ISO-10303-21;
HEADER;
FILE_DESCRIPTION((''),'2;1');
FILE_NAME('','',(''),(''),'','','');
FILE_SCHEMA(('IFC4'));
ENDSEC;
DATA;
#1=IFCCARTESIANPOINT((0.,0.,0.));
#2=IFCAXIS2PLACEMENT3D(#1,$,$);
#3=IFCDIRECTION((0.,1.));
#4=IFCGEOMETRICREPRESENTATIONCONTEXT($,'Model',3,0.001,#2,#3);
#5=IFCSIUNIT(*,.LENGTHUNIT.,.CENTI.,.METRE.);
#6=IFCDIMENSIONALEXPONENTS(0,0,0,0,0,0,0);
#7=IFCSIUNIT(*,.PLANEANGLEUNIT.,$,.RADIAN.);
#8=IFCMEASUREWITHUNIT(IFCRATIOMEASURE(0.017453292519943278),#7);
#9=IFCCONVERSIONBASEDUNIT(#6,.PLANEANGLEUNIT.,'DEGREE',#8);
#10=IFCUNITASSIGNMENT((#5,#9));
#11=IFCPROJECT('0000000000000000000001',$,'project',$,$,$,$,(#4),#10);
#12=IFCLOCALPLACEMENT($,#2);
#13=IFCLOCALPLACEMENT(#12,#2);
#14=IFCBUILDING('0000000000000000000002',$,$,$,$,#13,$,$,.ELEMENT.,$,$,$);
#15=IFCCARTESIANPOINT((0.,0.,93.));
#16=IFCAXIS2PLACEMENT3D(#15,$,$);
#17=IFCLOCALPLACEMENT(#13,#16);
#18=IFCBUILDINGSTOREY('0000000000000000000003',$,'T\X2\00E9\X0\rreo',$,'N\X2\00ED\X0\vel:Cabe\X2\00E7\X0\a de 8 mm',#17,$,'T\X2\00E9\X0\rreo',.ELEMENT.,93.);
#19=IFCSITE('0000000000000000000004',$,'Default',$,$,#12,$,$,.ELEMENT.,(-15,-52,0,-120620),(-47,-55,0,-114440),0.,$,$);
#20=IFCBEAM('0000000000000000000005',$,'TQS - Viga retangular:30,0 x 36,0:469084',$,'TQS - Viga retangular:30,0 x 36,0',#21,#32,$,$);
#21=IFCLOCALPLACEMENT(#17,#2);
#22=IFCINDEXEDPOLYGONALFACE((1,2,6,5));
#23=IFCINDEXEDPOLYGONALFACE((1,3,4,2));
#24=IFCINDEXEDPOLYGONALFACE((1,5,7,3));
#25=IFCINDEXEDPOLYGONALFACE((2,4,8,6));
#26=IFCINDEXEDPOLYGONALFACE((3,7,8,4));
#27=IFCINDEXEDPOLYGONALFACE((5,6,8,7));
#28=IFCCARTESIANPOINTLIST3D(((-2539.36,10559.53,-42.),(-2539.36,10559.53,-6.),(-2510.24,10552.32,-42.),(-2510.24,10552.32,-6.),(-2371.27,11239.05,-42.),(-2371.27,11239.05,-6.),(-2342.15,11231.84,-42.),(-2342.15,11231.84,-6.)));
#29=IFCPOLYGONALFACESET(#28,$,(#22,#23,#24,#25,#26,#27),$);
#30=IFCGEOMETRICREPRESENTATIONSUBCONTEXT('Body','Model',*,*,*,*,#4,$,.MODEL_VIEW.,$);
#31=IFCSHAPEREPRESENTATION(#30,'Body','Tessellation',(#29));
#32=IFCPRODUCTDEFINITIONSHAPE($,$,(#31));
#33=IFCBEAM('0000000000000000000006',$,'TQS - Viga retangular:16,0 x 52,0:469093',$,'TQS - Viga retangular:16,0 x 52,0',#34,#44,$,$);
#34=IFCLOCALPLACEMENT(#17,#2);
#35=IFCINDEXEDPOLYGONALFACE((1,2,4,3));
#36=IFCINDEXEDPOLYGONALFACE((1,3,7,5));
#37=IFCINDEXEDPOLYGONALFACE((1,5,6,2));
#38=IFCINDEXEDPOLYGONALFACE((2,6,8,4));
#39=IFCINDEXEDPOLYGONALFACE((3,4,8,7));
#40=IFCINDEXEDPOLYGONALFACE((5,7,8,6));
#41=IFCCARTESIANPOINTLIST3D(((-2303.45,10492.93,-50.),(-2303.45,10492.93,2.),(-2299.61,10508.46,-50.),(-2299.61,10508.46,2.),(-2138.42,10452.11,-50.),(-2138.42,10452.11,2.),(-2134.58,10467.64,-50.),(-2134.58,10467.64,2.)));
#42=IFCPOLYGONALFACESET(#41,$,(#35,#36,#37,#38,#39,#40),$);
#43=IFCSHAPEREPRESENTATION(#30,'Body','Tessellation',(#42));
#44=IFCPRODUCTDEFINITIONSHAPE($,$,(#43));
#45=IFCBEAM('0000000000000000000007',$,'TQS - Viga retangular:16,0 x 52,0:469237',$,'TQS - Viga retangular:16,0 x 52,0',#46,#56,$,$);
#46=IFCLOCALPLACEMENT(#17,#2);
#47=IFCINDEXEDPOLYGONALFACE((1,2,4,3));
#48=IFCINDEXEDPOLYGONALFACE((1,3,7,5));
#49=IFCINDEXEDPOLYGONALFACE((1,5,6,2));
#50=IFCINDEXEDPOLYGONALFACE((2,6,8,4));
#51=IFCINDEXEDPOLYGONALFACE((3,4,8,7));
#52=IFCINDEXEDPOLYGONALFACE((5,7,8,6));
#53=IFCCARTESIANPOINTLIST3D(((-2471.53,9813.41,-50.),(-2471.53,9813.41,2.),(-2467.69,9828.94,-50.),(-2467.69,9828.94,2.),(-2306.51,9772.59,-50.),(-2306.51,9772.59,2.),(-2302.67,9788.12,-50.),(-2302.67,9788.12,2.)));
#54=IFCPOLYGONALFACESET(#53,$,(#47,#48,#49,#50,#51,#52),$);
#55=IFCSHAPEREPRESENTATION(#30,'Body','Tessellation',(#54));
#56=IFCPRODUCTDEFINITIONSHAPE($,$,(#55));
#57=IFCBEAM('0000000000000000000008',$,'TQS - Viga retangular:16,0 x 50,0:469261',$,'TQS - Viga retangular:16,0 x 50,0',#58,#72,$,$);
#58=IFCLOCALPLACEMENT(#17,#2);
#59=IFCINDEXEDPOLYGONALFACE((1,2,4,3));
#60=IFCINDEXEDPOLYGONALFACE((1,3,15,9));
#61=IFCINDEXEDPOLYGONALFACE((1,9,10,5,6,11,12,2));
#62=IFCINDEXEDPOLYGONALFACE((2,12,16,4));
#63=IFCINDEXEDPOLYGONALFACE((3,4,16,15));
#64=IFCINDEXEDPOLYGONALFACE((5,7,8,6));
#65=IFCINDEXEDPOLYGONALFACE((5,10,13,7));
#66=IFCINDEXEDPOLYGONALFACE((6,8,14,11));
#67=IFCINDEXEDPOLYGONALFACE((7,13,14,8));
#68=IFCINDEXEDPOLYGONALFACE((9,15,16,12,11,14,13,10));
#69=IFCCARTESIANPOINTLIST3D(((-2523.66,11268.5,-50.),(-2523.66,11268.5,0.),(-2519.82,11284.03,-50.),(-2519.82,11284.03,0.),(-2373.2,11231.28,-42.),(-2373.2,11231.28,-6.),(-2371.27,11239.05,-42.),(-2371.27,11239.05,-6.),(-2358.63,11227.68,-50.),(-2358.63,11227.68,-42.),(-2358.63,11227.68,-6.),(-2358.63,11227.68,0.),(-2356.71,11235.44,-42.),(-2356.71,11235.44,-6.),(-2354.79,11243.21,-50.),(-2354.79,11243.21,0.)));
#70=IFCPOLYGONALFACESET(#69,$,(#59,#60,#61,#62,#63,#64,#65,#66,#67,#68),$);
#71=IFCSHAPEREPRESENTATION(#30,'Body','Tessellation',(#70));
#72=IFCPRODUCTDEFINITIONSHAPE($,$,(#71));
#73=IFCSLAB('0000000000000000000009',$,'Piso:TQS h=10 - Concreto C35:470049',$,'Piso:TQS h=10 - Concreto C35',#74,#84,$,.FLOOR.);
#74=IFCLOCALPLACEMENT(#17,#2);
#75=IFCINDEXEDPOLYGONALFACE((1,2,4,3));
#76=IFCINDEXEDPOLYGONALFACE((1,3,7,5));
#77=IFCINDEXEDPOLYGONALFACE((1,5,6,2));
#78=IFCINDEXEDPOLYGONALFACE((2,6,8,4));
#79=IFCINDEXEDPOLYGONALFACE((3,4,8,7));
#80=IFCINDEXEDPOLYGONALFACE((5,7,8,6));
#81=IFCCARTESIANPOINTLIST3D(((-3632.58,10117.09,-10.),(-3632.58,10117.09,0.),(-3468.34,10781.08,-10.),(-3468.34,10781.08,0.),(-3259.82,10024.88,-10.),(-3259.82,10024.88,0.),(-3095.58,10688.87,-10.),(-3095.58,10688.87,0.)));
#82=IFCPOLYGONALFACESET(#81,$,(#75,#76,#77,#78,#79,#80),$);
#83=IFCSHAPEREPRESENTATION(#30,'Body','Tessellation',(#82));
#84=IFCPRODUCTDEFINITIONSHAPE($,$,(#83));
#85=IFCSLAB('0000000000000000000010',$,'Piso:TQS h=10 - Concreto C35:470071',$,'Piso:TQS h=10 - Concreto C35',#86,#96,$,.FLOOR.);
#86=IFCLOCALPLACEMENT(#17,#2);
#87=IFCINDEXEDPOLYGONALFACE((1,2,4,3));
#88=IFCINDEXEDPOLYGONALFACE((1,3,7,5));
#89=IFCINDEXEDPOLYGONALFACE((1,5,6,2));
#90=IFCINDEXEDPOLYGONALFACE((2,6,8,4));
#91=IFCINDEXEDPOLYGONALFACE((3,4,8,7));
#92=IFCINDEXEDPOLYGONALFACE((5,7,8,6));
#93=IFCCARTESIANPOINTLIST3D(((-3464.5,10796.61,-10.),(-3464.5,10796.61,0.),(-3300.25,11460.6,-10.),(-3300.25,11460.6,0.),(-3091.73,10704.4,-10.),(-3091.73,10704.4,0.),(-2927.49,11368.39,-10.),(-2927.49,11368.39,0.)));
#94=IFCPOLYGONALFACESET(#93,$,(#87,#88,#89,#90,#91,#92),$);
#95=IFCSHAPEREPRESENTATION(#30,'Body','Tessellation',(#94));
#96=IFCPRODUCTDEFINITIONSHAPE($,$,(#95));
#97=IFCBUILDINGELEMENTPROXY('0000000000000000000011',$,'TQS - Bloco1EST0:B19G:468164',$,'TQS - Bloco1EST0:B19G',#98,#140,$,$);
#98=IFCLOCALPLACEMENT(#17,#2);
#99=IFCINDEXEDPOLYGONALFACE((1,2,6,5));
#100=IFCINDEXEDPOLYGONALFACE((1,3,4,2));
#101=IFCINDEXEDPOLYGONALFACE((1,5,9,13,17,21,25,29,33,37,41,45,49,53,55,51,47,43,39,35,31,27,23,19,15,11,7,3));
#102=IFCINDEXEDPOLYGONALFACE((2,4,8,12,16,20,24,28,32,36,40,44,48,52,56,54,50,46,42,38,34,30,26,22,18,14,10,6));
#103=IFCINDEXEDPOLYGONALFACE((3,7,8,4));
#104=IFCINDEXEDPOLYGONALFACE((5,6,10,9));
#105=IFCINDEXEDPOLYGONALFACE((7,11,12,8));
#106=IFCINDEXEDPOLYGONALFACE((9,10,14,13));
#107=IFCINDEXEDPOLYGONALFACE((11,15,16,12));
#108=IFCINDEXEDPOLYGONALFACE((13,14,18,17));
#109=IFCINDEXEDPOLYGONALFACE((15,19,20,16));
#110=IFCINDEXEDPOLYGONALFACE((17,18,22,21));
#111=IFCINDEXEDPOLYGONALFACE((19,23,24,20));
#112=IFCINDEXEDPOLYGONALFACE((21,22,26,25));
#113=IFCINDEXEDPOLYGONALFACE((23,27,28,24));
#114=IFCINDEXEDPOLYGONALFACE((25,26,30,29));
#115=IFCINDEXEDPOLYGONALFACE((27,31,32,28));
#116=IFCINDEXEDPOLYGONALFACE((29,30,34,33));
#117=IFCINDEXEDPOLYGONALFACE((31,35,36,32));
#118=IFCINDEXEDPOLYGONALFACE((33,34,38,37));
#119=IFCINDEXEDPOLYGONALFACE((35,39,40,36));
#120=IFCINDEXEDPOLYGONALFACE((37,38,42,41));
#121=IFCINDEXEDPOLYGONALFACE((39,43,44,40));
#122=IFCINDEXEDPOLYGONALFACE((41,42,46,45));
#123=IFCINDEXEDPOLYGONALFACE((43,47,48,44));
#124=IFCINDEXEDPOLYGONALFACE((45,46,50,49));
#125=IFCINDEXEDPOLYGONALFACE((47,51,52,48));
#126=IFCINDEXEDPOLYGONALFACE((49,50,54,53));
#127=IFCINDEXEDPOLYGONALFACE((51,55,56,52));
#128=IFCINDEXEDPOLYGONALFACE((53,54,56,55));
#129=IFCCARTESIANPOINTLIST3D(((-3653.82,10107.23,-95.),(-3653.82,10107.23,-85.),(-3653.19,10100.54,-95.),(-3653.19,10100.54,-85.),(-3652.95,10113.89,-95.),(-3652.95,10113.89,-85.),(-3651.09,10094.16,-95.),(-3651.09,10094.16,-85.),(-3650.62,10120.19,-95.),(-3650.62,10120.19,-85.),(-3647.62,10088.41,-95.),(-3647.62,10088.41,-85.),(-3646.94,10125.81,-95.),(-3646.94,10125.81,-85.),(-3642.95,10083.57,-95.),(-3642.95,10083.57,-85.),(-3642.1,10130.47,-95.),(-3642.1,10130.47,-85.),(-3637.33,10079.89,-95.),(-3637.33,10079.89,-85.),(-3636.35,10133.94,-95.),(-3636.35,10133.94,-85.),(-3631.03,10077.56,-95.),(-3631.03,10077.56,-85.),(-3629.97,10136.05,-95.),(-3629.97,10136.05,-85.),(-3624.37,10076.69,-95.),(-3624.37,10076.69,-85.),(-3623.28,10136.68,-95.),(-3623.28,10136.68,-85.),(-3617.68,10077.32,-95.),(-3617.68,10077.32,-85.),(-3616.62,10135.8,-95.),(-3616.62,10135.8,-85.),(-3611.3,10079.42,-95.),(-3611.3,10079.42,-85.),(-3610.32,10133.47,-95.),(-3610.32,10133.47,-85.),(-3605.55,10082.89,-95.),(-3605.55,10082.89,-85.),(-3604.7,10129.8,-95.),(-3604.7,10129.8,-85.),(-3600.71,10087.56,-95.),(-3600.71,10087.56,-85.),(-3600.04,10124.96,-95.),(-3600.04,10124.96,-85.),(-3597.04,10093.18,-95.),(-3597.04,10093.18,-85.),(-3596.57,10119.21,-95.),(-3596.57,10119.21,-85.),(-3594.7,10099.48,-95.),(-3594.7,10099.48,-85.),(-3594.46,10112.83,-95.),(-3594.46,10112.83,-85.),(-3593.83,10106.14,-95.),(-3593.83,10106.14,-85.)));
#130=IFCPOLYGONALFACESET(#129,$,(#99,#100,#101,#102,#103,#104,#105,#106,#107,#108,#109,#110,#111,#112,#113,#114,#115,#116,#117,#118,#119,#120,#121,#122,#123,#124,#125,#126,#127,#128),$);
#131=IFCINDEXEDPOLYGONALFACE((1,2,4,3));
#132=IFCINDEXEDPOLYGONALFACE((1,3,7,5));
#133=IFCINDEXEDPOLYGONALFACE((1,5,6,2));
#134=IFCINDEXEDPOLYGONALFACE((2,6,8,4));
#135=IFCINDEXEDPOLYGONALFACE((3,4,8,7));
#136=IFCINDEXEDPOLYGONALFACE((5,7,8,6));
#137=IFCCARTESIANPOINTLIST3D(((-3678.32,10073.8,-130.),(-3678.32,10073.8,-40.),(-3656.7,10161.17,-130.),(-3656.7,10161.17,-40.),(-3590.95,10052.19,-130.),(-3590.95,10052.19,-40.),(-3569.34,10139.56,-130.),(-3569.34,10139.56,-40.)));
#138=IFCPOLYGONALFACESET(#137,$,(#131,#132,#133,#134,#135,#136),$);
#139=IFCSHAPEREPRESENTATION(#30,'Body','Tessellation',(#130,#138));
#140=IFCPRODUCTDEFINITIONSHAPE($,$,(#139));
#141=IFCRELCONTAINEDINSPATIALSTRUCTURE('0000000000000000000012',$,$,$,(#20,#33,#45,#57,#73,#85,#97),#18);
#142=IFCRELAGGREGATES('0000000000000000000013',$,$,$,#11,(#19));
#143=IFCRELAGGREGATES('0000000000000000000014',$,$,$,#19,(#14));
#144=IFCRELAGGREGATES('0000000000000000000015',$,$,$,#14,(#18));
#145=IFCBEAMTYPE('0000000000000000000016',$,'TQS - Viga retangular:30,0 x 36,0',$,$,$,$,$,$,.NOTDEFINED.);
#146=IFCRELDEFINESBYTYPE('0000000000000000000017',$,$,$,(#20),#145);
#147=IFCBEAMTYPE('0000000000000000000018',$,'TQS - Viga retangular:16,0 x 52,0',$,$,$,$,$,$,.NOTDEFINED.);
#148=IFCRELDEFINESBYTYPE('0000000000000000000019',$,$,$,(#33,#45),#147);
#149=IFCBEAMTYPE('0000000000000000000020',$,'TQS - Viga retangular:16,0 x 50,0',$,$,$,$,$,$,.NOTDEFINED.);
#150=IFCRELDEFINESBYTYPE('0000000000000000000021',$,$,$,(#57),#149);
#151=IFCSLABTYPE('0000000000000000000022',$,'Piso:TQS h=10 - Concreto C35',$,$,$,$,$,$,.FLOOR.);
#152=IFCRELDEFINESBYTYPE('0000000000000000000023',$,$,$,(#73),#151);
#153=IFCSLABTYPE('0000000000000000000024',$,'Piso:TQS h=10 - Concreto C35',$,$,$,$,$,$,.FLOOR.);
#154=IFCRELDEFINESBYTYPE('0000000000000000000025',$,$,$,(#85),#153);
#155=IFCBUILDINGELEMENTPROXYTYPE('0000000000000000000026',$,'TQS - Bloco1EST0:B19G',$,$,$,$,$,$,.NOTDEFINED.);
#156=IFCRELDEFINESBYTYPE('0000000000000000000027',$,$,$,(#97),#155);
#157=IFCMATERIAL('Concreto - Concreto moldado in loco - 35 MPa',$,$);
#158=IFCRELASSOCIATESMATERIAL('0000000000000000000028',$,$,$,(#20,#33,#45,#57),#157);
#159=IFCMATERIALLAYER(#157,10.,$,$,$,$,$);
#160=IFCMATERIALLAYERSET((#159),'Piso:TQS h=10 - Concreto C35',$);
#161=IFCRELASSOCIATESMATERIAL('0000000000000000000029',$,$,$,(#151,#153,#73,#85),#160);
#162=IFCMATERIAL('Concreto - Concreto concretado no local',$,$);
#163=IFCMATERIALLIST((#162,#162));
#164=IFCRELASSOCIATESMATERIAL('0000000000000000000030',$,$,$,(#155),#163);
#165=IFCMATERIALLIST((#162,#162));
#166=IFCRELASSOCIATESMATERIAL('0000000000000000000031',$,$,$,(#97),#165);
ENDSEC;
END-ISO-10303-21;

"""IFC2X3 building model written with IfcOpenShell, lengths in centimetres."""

from ifc_helpers import new_model, entity, si_unit, converted_unit, direction, frame, frame_2d, origin, origin_2d_with_axis, place, context, subcontext, project, spatial, polyline, rectangle, circle, extrude, boolean, clip, bounded_halfspace, source, transform, mapped, material, material_list, layer, layer_set, layer_usage, type_object, type_shapes, element, save


model = new_model("IFC2X3")

# Units and contexts
model_context = context("Model", 3, precision=0.001, world=origin(), true_north=direction((0.0, 1.0)))
body_context = subcontext(model_context, "Body", "Model", "MODEL_VIEW")
ifc_project = project(units=[si_unit("LENGTHUNIT", "METRE", prefix="CENTI"), converted_unit("PLANEANGLEUNIT", "DEGREE", entity("IfcRatioMeasure", 0.017453292519943278), si_unit("PLANEANGLEUNIT", "RADIAN"), dimensions=[0, 0, 0, 0, 0, 0, 0])], contexts=[model_context])

# Site, building, storey
site_placement = place(None, origin())
site = spatial("IfcSite", under=ifc_project, at=site_placement, Name="Default", CompositionType="ELEMENT", RefLatitude=(-15, -52, 0, -120620), RefLongitude=(-47, -55, 0, -114440), RefElevation=0.0)
building_placement = place(site_placement, origin())
building = spatial("IfcBuilding", under=site, at=building_placement, CompositionType="ELEMENT")
storey_placement = place(building_placement, frame((0.0, 0.0, 93.0)))
storey = spatial("IfcBuildingStorey", under=building, at=storey_placement, Name="Térreo", ObjectType="Nível:Cabeça de 8 mm", LongName="Térreo", CompositionType="ELEMENT", Elevation=93.0)

# Beams
ifc_material_1 = material(Name="Concreto - Concreto moldado in loco - 35 MPa")
beam_type_1 = type_object("IfcBeamType", Name="TQS - Viga retangular:30,0 x 36,0", PredefinedType="NOTDEFINED")
beam_1_placement = place(storey_placement, frame((-2524.8, 10555.93, -6.0), z_axis=(0.0, 0.0, 1.0), x_axis=(0.240122, 0.970743, 0.0)))
element("IfcBeam", 1, at=beam_1_placement, inside=storey, type_object=beam_type_1, material=ifc_material_1, Name="TQS - Viga retangular:30,0 x 36,0:469084", ObjectType="TQS - Viga retangular:30,0 x 36,0", context=body_context, shape_type="SweptSolid", body=[
    extrude(rectangle(XDim=36.0, YDim=30.0, at=origin_2d_with_axis()), frame((0.0, 0.0, -18.0), z_axis=(1.0, 0.0, 0.0), x_axis=(0.0, 0.0, -1.0)), (0.0, 0.0, 1.0), 700.0),
])
beam_type_2 = type_object("IfcBeamType", Name="TQS - Viga retangular:16,0 x 52,0", PredefinedType="NOTDEFINED")
beam_2_placement = place(storey_placement, frame((-2136.5, 10459.88, 2.0), z_axis=(0.0, 0.0, 1.0), x_axis=(-0.970743, 0.240122, 0.0)))
element("IfcBeam", 2, at=beam_2_placement, inside=storey, type_object=beam_type_2, material=ifc_material_1, Name="TQS - Viga retangular:16,0 x 52,0:469093", ObjectType="TQS - Viga retangular:16,0 x 52,0", context=body_context, shape_type="SweptSolid", body=[
    extrude(rectangle(XDim=52.0, YDim=16.0, at=frame_2d((0.0, 0.0), x_axis=(1.0, 0.0))), frame((0.0, 0.0, -26.0), z_axis=(1.0, 0.0, 0.0), x_axis=(0.0, 0.0, -1.0)), (0.0, 0.0, 1.0), 170.0),
])
beam_3_placement = place(storey_placement, frame((-2304.59, 9780.36, 2.0), z_axis=(0.0, 0.0, 1.0), x_axis=(-0.970743, 0.240122, 0.0)))
element("IfcBeam", 3, at=beam_3_placement, inside=storey, type_object=beam_type_2, material=ifc_material_1, Name="TQS - Viga retangular:16,0 x 52,0:469237", ObjectType="TQS - Viga retangular:16,0 x 52,0", context=body_context, shape_type="SweptSolid", body=[
    extrude(rectangle(XDim=52.0, YDim=16.0, at=frame_2d((0.0, 0.0), x_axis=(1.0, 0.0))), frame((0.0, 0.0, -26.0), z_axis=(1.0, 0.0, 0.0), x_axis=(0.0, 0.0, -1.0)), (0.0, 0.0, 1.0), 170.0),
])
beam_type_3 = type_object("IfcBeamType", Name="TQS - Viga retangular:16,0 x 50,0", PredefinedType="NOTDEFINED")
beam_4_placement = place(storey_placement, frame((-2356.71, 11235.44, 0.0), z_axis=(0.0, 0.0, 1.0), x_axis=(-0.970743, 0.240122, 0.0)))
element("IfcBeam", 4, at=beam_4_placement, inside=storey, type_object=beam_type_3, material=ifc_material_1, Name="TQS - Viga retangular:16,0 x 50,0:469261", ObjectType="TQS - Viga retangular:16,0 x 50,0", context=body_context, shape_type="SweptSolid", body=[
    boolean("DIFFERENCE", clip(extrude(rectangle(XDim=50.0, YDim=16.0, at=frame_2d((0.0, 0.0), x_axis=(1.0, 0.0))), frame((0.0, 0.0, -25.0), z_axis=(1.0, 0.0, 0.0), x_axis=(0.0, 0.0, -1.0)), (0.0, 0.0, 1.0), 170.0), bounded_halfspace(frame((15.0, 0.0, -42.0), z_axis=(-1.0, 0.0, 0.0), x_axis=(0.0, 1.0, 0.0)), False, frame((0.0, 0.0, -25.0), z_axis=(1.0, 0.0, 0.0), x_axis=(0.0, 0.0, -1.0)), polyline([(17.0, 0.0), (-19.0, 0.0), (-19.0, 8.0), (-9.0, 8.0), (17.0, 8.0), (17.0, 0.0)]))), extrude(rectangle(XDim=36.0, YDim=8.0, at=frame_2d((0.0, 0.0), x_axis=(0.0, 1.0))), frame((0.0, 4.0, -24.0), z_axis=(-1.0, 0.0, 0.0), x_axis=(0.0, -1.0, 0.0)), (0.0, 0.0, -1.0), 15.0)),
])

# Slabs
ifc_layer = layer(ifc_material_1, 10.0)
ifc_layer_set = layer_set([ifc_layer], Name="Piso:TQS h=10 - Concreto C35")
ifc_layer_usage_1 = layer_usage(ifc_layer_set, "AXIS3", "POSITIVE", 0.0)
slab_type_1 = type_object("IfcSlabType", Name="Piso:TQS h=10 - Concreto C35", PredefinedType="FLOOR", material=ifc_layer_set)
slab_1_placement = place(storey_placement, origin())
element("IfcSlab", 5, at=slab_1_placement, inside=storey, type_object=slab_type_1, material=ifc_layer_usage_1, Name="Piso:TQS h=10 - Concreto C35:470049", ObjectType="Piso:TQS h=10 - Concreto C35", PredefinedType="FLOOR", context=body_context, shape_type="SweptSolid", body=[
    extrude(rectangle(XDim=384.0, YDim=684.0, at=frame_2d((0.0, 0.0), x_axis=(1.0, 0.0))), frame((-3364.08, 10402.98, 0.0), z_axis=(0.0, 0.0, -1.0), x_axis=(0.970743, -0.240122, 0.0)), (0.0, 0.0, 1.0), 10.0),
])
ifc_layer_usage_2 = layer_usage(ifc_layer_set, "AXIS3", "POSITIVE", 0.0)
slab_type_2 = type_object("IfcSlabType", Name="Piso:TQS h=10 - Concreto C35", PredefinedType="FLOOR", material=ifc_layer_set)
slab_2_placement = place(storey_placement, origin())
element("IfcSlab", 6, at=slab_2_placement, inside=storey, type_object=slab_type_2, material=ifc_layer_usage_2, Name="Piso:TQS h=10 - Concreto C35:470071", ObjectType="Piso:TQS h=10 - Concreto C35", PredefinedType="FLOOR", context=body_context, shape_type="SweptSolid", body=[
    extrude(rectangle(XDim=684.0, YDim=384.0, at=frame_2d((0.0, 0.0), x_axis=(1.0, 0.0))), frame((-3195.99, 11082.5, 0.0), z_axis=(0.0, 0.0, -1.0), x_axis=(-0.240122, -0.970743, 0.0)), (0.0, 0.0, 1.0), 10.0),
])

# Building element proxy
ifc_material_2 = material(Name="Concreto - Concreto concretado no local")
ifc_material_list_1 = material_list([ifc_material_2, ifc_material_2])
ifc_material_list_2 = material_list([ifc_material_2, ifc_material_2])
building_element_proxy_type_1 = type_object("IfcBuildingElementProxyType", Name="TQS - Bloco1EST0:B19G", PredefinedType="NOTDEFINED", material=ifc_material_list_2)
shared_shape_1 = source(origin(), body_context, "Body", "SweptSolid", [
    extrude(circle(Radius=30.0, at=frame_2d((0.0, 0.0), x_axis=(1.0, 0.0))), frame((0.0, 0.0, -55.0)), (0.0, 0.0, 1.0), 10.0),
    extrude(rectangle(XDim=90.0, YDim=90.0, at=origin_2d_with_axis()), frame((0.0, 0.0, -90.0), z_axis=(0.0, 0.0, 1.0), x_axis=(-1.0, 0.0, 0.0)), (0.0, 0.0, 1.0), 90.0),
])
type_shapes(building_element_proxy_type_1, [shared_shape_1])
proxy_1_placement = place(storey_placement, frame((-3623.83, 10106.68, -40.0), z_axis=(0.0, 0.0, 1.0), x_axis=(0.240122, 0.970743, 0.0)))
element("IfcBuildingElementProxy", 7, at=proxy_1_placement, inside=storey, type_object=building_element_proxy_type_1, material=ifc_material_list_1, Name="TQS - Bloco1EST0:B19G:468164", ObjectType="TQS - Bloco1EST0:B19G", context=body_context, shape_type="MappedRepresentation", body=[
    mapped(shared_shape_1, transform((0.0, 0.0, 0.0), scale=1.0)),
])

save(model, "model.ifc")
